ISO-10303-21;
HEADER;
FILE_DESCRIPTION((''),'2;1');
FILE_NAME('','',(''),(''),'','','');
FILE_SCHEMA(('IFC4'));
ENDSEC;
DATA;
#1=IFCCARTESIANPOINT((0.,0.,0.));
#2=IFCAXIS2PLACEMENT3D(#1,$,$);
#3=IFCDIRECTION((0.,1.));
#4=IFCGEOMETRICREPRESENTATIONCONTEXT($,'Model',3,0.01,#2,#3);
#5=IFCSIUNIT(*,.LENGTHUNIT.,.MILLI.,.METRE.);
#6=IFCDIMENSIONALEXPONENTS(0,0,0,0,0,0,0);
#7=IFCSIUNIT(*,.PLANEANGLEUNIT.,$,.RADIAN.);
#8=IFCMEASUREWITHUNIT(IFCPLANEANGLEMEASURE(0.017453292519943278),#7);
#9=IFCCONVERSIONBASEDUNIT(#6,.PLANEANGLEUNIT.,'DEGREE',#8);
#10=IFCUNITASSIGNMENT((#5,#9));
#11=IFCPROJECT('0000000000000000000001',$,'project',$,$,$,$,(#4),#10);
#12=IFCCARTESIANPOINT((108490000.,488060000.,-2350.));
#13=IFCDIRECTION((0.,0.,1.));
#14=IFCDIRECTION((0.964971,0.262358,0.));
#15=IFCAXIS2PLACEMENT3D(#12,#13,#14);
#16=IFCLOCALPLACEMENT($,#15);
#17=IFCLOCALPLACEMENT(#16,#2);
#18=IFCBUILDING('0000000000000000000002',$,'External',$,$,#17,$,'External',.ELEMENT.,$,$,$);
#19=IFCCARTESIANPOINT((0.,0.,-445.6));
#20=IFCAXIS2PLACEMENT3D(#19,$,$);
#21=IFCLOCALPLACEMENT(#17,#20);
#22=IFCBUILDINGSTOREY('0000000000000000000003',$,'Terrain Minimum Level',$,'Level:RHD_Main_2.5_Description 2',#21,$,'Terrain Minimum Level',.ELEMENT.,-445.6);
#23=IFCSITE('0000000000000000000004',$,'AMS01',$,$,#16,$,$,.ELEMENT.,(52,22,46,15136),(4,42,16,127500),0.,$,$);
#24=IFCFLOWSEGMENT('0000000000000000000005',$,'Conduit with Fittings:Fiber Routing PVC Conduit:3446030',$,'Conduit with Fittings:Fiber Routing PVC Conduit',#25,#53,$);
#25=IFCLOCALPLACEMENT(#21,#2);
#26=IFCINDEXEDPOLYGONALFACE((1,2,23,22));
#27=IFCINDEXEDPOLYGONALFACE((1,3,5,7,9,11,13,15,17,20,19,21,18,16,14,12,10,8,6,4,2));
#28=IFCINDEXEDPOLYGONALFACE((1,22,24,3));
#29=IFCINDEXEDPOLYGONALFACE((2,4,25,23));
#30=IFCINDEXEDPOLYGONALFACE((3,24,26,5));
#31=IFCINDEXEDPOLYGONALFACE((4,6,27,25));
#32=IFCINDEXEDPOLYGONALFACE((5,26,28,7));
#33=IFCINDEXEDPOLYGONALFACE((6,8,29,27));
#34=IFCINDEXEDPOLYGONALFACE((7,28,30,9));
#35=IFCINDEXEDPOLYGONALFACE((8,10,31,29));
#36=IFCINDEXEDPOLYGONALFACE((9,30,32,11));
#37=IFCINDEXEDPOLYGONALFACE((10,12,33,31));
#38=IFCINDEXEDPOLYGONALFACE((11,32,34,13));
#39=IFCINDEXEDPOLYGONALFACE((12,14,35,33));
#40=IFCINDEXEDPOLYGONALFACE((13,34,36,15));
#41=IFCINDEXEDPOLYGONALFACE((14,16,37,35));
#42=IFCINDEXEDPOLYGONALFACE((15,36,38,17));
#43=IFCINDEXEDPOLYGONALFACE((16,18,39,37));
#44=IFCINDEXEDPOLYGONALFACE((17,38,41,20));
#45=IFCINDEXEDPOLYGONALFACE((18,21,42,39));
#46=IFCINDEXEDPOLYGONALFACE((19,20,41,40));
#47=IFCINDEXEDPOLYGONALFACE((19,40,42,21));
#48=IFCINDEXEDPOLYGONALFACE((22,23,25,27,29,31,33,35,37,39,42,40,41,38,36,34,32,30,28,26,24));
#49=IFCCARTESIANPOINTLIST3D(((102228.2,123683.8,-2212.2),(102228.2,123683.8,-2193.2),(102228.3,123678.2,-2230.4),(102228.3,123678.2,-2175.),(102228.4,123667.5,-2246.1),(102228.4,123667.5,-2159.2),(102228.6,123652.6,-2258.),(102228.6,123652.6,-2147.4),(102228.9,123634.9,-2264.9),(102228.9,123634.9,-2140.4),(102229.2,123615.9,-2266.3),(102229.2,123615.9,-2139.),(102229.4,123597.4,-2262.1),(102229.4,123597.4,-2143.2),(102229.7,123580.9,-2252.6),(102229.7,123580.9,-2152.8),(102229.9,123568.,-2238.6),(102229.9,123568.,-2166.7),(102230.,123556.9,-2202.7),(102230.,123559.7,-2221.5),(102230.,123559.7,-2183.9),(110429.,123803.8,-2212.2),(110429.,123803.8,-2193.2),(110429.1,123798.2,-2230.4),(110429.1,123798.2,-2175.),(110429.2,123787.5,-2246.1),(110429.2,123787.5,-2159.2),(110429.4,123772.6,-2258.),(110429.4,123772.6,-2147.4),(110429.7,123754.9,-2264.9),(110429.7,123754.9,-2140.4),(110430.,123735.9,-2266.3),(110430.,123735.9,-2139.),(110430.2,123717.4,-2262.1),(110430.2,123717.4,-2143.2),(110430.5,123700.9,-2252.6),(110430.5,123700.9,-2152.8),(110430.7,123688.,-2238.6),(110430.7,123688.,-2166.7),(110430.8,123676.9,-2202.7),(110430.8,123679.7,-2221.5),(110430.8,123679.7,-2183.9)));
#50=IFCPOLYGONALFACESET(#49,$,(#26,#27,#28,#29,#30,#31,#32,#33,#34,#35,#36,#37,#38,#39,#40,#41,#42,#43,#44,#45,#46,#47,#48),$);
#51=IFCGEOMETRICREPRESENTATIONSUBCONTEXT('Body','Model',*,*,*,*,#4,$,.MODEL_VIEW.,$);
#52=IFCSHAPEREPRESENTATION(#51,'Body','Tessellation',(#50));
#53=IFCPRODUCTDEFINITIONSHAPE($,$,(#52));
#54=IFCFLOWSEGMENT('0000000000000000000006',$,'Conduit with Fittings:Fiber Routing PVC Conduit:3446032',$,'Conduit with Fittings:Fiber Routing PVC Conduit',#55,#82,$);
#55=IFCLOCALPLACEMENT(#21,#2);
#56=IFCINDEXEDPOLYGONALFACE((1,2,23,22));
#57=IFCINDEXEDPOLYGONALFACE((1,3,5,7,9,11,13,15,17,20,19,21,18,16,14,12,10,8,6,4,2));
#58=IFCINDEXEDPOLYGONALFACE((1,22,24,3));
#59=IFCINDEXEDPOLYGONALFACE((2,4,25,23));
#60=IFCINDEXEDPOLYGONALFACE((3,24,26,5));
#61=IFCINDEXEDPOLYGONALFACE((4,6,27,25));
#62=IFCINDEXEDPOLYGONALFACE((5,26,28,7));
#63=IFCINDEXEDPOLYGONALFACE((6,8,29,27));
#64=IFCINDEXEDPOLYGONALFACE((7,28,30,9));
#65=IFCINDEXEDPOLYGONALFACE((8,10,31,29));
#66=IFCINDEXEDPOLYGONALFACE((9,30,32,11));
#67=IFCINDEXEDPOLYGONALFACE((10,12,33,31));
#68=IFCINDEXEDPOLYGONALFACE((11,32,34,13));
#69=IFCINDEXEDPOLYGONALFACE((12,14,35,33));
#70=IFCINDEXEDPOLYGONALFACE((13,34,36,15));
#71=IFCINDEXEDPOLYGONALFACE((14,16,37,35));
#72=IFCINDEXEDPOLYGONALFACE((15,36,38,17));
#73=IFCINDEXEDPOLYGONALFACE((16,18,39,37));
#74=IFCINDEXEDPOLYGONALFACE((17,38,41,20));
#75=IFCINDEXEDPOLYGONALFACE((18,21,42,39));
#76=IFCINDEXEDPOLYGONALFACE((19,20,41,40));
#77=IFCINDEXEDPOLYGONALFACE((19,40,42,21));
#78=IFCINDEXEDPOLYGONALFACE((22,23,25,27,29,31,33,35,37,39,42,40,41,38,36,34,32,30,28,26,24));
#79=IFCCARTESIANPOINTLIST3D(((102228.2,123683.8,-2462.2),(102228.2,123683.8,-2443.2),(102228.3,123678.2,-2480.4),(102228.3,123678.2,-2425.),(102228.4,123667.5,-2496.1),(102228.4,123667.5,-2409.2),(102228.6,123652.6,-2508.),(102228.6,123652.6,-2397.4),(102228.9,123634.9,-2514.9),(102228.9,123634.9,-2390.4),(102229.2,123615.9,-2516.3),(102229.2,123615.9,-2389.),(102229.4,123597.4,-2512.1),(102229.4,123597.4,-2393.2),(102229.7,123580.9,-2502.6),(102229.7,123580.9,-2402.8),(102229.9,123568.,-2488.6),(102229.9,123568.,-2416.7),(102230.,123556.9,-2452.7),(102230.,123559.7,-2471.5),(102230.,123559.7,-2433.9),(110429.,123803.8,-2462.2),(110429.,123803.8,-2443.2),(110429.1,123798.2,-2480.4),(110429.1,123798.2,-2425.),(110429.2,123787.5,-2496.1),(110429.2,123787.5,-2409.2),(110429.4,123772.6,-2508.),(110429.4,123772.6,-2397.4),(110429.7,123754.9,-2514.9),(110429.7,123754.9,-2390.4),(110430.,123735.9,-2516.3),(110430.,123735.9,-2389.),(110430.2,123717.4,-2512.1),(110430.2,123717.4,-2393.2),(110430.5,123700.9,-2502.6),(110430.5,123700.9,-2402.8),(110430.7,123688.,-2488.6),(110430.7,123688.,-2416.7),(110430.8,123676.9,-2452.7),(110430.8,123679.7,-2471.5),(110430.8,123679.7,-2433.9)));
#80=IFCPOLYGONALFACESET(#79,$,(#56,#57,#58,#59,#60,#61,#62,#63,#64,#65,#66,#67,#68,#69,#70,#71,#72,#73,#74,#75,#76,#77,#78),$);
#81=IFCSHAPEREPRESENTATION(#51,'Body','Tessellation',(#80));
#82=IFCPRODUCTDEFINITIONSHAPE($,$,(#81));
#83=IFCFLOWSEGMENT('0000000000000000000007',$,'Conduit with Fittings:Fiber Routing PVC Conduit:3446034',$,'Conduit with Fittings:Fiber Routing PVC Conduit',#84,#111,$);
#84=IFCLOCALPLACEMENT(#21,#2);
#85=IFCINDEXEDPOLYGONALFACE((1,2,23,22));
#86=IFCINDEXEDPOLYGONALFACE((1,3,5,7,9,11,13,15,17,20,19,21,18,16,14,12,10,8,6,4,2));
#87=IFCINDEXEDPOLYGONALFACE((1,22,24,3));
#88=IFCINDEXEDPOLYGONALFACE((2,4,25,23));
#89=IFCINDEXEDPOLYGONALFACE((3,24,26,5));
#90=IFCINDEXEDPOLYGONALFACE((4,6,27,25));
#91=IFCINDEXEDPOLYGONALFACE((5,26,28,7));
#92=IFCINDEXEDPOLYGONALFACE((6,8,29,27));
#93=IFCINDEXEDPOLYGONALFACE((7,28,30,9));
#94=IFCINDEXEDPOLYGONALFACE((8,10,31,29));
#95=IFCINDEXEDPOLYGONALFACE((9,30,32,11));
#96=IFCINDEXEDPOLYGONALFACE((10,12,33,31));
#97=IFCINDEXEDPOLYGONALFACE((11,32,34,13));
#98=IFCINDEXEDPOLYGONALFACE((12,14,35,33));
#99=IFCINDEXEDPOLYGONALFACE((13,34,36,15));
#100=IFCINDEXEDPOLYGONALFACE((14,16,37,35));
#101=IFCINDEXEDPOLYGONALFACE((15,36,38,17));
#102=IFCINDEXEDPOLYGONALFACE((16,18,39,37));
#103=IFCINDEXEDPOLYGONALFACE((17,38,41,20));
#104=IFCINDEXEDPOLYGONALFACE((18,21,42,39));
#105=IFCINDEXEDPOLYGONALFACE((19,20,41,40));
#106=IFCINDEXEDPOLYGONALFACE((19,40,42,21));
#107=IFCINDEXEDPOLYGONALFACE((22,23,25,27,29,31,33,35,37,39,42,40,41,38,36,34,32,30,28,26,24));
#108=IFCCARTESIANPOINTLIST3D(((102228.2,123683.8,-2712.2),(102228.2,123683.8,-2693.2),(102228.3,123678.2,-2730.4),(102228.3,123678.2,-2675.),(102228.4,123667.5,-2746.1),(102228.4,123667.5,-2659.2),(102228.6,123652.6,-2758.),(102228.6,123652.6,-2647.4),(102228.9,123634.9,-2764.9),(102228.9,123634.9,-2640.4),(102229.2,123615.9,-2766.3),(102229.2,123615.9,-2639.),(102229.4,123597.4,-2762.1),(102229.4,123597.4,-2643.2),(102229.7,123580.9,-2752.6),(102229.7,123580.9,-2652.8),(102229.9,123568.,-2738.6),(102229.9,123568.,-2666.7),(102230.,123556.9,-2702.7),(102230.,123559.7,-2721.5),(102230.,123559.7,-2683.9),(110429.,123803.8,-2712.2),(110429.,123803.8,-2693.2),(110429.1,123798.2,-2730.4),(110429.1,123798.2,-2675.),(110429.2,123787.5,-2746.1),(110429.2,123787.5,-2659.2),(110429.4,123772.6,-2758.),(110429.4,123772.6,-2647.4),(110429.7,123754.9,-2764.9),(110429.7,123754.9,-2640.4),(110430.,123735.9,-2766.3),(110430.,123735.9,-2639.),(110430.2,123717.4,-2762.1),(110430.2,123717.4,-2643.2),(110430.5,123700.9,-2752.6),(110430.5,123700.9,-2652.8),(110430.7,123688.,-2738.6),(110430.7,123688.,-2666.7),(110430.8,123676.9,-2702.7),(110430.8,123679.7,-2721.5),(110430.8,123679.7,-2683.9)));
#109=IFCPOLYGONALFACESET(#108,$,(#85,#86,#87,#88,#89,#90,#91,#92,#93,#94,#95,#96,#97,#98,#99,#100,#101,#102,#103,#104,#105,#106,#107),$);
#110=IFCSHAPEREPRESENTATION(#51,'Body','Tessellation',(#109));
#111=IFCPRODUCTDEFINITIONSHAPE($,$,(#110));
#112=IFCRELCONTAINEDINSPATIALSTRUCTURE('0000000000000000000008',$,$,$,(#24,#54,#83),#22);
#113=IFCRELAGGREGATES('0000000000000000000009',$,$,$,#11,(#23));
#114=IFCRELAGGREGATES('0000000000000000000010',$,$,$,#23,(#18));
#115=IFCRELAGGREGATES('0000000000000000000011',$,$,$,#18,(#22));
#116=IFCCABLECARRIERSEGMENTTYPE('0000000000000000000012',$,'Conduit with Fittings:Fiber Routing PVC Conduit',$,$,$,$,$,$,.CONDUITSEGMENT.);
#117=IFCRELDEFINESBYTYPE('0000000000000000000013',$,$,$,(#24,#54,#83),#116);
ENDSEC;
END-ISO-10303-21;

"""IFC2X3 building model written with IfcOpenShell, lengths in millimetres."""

from ifc_helpers import new_model, entity, si_unit, converted_unit, direction, frame, frame_2d, origin, origin_2d_with_axis, place, context, subcontext, project, spatial, circle, extrude, type_object, element, save


model = new_model("IFC2X3")

# Units and contexts
model_context = context("Model", 3, precision=0.01, world=origin(), true_north=direction((0.0, 1.0)))
body_context = subcontext(model_context, "Body", "Model", "MODEL_VIEW")
ifc_project = project(units=[si_unit("LENGTHUNIT", "METRE", prefix="MILLI"), converted_unit("PLANEANGLEUNIT", "DEGREE", entity("IfcPlaneAngleMeasure", 0.017453292519943278), si_unit("PLANEANGLEUNIT", "RADIAN"), dimensions=[0, 0, 0, 0, 0, 0, 0])], contexts=[model_context])

# Site, building, storey
site_placement = place(None, frame((108490000.0, 488060000.0, -2350.0), z_axis=(0.0, 0.0, 1.0), x_axis=(0.964971, 0.262358, 0.0)))
site = spatial("IfcSite", under=ifc_project, at=site_placement, Name="AMS01", CompositionType="ELEMENT", RefLatitude=(52, 22, 46, 15136), RefLongitude=(4, 42, 16, 127500), RefElevation=0.0)
building_placement = place(site_placement, origin())
building = spatial("IfcBuilding", under=site, at=building_placement, Name="External", LongName="External", CompositionType="ELEMENT")
storey_placement = place(building_placement, frame((0.0, 0.0, -445.6)))
storey = spatial("IfcBuildingStorey", under=building, at=storey_placement, Name="Terrain Minimum Level", ObjectType="Level:RHD_Main_2.5_Description 2", LongName="Terrain Minimum Level", CompositionType="ELEMENT", Elevation=-445.6)

# Flow segments
cable_carrier_segment_type = type_object("IfcCableCarrierSegmentType", Name="Conduit with Fittings:Fiber Routing PVC Conduit", PredefinedType="CONDUITSEGMENT")
flow_segment_1_placement = place(storey_placement, origin())
element("IfcFlowSegment", 1, at=flow_segment_1_placement, inside=storey, type_object=cable_carrier_segment_type, Name="Conduit with Fittings:Fiber Routing PVC Conduit:3446030", ObjectType="Conduit with Fittings:Fiber Routing PVC Conduit", context=body_context, shape_type="SweptSolid", body=[
    extrude(circle(Radius=63.9, at=origin_2d_with_axis()), frame((102229.1, 123620.7, -2202.7), z_axis=(0.999893, 0.014631, 0.0), x_axis=(0.014631, -0.999893, 0.0)), (0.0, 0.0, 1.0), 8201.7),
])
flow_segment_2_placement = place(storey_placement, origin())
element("IfcFlowSegment", 2, at=flow_segment_2_placement, inside=storey, type_object=cable_carrier_segment_type, Name="Conduit with Fittings:Fiber Routing PVC Conduit:3446032", ObjectType="Conduit with Fittings:Fiber Routing PVC Conduit", context=body_context, shape_type="SweptSolid", body=[
    extrude(circle(Radius=63.9, at=origin_2d_with_axis()), frame((102229.1, 123620.7, -2452.7), z_axis=(0.999893, 0.014631, 0.0), x_axis=(0.014631, -0.999893, 0.0)), (0.0, 0.0, 1.0), 8201.7),
])
flow_segment_3_placement = place(storey_placement, origin())
element("IfcFlowSegment", 3, at=flow_segment_3_placement, inside=storey, type_object=cable_carrier_segment_type, Name="Conduit with Fittings:Fiber Routing PVC Conduit:3446034", ObjectType="Conduit with Fittings:Fiber Routing PVC Conduit", context=body_context, shape_type="SweptSolid", body=[
    extrude(circle(Radius=63.9, at=frame_2d((0.0, 0.0), x_axis=(1.0, 0.0))), frame((102229.1, 123620.7, -2702.7), z_axis=(0.999893, 0.014631, 0.0), x_axis=(0.014631, -0.999893, 0.0)), (0.0, 0.0, 1.0), 8201.7),
])

save(model, "model.ifc")
